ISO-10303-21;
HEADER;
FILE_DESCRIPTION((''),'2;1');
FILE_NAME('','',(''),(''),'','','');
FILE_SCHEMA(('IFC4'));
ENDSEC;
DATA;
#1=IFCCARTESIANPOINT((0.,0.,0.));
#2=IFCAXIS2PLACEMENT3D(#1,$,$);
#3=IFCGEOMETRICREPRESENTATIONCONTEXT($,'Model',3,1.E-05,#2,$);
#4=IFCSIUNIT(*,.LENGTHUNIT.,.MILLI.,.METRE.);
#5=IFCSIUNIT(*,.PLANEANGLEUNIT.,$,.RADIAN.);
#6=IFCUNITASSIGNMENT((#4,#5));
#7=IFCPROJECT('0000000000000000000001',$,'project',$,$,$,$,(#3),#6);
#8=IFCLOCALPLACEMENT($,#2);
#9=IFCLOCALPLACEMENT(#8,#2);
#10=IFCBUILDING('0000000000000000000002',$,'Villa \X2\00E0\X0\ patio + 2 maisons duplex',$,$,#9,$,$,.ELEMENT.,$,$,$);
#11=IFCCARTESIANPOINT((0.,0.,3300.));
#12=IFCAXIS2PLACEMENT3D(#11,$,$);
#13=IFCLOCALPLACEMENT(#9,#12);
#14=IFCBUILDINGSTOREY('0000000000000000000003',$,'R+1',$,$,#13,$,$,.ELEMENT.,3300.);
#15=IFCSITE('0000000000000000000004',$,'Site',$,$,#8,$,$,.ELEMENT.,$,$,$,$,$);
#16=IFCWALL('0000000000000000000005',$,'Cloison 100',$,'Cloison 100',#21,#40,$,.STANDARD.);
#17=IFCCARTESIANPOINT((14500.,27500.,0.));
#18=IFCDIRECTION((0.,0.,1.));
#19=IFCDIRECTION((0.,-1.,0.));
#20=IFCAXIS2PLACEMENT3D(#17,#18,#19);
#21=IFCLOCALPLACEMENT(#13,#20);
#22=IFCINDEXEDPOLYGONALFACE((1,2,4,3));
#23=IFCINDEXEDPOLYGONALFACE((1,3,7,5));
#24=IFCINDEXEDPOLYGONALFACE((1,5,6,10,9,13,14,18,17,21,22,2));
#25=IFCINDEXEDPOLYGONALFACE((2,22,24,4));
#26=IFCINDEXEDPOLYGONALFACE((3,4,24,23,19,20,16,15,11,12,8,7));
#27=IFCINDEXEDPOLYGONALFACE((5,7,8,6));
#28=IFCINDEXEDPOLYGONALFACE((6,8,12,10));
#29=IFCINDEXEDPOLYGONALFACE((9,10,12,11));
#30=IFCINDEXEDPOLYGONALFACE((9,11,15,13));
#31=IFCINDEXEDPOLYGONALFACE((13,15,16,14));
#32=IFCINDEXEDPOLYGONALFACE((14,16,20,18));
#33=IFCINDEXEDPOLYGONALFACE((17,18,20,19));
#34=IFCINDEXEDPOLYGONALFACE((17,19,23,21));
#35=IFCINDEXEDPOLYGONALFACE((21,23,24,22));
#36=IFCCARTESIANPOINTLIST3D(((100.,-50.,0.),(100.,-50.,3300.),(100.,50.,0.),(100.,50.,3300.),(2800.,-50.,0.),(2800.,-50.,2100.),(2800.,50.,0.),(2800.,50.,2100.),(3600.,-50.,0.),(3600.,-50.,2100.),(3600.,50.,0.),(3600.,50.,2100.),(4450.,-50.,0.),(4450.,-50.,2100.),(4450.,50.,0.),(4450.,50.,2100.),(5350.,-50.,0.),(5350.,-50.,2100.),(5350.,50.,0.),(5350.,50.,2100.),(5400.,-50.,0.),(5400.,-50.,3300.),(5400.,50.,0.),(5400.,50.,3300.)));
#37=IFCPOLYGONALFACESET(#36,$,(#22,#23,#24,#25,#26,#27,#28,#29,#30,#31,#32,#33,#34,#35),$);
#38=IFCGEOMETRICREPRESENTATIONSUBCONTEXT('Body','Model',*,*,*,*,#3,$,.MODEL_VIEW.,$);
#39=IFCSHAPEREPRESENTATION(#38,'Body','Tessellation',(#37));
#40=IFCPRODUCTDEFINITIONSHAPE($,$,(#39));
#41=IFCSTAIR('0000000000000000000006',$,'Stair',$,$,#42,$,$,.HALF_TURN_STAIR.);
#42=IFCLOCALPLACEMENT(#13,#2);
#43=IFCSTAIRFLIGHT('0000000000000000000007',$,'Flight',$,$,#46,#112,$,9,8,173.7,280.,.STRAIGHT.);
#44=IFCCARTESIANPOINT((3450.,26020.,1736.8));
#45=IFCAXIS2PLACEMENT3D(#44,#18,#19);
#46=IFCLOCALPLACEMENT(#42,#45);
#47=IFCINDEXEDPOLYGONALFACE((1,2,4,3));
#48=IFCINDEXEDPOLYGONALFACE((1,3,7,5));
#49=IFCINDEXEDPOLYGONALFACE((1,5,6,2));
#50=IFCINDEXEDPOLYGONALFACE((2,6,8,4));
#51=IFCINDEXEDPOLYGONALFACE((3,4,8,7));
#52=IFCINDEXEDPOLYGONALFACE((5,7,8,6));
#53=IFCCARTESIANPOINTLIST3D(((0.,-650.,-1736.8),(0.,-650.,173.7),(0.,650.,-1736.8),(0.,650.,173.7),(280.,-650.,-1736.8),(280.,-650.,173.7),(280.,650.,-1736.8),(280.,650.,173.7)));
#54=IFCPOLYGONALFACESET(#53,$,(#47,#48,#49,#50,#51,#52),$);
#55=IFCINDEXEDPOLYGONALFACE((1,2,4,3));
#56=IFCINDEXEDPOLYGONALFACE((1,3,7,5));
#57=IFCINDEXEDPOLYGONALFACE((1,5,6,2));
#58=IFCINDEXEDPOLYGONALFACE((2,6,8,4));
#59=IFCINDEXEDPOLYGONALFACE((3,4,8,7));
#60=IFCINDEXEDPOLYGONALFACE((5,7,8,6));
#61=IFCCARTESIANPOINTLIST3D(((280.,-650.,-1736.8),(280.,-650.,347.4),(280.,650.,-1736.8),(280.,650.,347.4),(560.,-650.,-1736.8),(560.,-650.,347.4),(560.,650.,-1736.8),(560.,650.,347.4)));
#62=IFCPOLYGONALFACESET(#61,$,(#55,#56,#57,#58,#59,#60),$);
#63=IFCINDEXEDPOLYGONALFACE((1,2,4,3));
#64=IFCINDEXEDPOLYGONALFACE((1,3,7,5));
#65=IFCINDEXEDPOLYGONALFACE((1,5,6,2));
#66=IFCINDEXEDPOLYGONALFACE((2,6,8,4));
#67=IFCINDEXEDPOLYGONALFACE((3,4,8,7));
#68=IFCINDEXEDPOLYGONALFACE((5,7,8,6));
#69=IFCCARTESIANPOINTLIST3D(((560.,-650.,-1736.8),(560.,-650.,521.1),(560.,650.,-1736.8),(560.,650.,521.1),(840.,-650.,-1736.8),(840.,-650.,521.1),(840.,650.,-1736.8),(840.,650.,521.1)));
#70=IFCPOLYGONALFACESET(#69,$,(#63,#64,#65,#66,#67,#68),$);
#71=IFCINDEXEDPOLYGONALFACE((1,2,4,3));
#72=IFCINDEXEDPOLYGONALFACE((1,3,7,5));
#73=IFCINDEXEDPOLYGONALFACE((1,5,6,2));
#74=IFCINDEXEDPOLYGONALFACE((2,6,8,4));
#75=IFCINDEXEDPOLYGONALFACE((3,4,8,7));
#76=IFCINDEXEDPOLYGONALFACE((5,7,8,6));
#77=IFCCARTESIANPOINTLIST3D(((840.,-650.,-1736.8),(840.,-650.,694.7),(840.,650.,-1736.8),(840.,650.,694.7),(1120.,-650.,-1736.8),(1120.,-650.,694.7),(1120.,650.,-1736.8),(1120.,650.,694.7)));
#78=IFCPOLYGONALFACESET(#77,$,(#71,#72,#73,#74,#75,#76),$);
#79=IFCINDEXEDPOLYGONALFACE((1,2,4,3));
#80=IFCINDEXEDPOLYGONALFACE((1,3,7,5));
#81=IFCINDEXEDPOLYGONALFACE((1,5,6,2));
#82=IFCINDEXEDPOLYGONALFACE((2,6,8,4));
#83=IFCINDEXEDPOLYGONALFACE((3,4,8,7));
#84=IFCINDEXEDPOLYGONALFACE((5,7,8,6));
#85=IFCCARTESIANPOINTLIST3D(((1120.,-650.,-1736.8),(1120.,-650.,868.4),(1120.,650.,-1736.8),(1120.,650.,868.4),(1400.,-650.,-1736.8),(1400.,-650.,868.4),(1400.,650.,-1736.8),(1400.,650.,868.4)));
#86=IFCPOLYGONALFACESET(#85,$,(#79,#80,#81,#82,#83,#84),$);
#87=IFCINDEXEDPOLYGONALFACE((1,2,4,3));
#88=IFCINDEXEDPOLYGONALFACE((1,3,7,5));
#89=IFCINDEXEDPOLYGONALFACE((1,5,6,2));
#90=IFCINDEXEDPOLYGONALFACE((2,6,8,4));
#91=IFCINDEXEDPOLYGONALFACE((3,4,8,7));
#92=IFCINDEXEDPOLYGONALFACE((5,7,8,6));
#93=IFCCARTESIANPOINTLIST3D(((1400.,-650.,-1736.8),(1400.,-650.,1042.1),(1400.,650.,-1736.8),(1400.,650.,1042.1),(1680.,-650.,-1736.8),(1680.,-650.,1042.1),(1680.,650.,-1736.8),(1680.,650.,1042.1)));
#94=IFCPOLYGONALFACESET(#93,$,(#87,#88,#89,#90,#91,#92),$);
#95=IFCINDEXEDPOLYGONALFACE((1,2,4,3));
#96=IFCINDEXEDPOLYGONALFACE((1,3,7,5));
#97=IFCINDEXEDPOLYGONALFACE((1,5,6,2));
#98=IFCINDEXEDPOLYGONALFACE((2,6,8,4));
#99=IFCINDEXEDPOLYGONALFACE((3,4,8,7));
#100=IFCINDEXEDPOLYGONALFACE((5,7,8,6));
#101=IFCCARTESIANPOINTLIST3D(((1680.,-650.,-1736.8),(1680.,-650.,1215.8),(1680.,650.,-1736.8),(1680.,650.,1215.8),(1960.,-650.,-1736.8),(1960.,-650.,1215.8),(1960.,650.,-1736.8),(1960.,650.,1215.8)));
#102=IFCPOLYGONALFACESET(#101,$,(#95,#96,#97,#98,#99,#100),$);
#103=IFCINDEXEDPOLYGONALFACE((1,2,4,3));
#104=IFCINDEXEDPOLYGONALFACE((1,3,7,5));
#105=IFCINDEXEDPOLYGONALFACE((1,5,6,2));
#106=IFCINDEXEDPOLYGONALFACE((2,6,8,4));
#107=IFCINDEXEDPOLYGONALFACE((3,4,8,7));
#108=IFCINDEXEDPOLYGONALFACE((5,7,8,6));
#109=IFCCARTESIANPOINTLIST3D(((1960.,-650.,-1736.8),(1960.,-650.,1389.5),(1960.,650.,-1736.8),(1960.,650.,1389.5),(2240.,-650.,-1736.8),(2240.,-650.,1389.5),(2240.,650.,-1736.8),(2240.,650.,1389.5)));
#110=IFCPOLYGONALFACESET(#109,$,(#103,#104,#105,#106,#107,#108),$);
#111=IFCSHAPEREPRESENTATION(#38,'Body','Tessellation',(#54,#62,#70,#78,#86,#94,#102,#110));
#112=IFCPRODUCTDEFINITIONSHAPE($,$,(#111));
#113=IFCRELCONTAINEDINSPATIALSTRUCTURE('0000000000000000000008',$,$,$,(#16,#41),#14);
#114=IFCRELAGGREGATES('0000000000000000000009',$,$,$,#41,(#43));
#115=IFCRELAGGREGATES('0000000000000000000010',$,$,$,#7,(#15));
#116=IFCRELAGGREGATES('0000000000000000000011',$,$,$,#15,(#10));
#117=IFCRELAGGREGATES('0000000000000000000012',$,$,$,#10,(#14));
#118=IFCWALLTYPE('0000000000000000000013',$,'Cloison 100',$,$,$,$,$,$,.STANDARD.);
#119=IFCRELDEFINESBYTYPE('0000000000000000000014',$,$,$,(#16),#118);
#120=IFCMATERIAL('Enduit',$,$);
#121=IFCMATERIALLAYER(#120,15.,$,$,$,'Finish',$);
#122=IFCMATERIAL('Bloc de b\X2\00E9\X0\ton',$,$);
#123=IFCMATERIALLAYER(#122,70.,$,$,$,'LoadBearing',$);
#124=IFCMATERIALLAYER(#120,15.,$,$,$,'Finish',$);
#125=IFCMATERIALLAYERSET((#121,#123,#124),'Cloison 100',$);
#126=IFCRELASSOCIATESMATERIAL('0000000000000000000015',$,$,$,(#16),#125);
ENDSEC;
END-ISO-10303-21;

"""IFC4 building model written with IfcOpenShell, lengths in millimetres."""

from ifc_helpers import new_model, si_unit, frame, frame_2d, origin, place, context, subcontext, project, spatial, polyline, rectangle, outline, extrude, material, layer, layer_set, layer_usage, type_object, element, aggregate, save


model = new_model("IFC4")

# Units and contexts
model_context = context("Model", 3, precision=1e-05, world=origin())
body_context = subcontext(model_context, "Body", "Model", "MODEL_VIEW")
ifc_project = project(units=[si_unit("LENGTHUNIT", "METRE", prefix="MILLI"), si_unit("PLANEANGLEUNIT", "RADIAN")], contexts=[model_context])

# Site, building, storey
site_placement = place(None, origin())
site = spatial("IfcSite", under=ifc_project, at=site_placement, Name="Site", CompositionType="ELEMENT")
building_placement = place(site_placement, origin())
building = spatial("IfcBuilding", under=site, at=building_placement, Name="Villa à patio + 2 maisons duplex", CompositionType="ELEMENT")
storey_placement = place(building_placement, frame((0.0, 0.0, 3300.0)))
storey = spatial("IfcBuildingStorey", under=building, at=storey_placement, Name="R+1", CompositionType="ELEMENT", Elevation=3300.0)

# Shared definitions
ifc_material_1 = material(Name="Enduit")
ifc_layer_1 = layer(ifc_material_1, 15.0, Category="Finish")
ifc_material_2 = material(Name="Bloc de béton")
ifc_layer_2 = layer(ifc_material_2, 70.0, Category="LoadBearing")
ifc_layer_3 = layer(ifc_material_1, 15.0, Category="Finish")
ifc_layer_set_1 = layer_set([ifc_layer_1, ifc_layer_2, ifc_layer_3], Name="Cloison 100")
ifc_layer_usage_1 = layer_usage(ifc_layer_set_1, "AXIS2", "NEGATIVE", 50.0)
wall_type_1 = type_object("IfcWallType", Name="Cloison 100", PredefinedType="STANDARD")

# Wall, openings
wall_1_placement = place(storey_placement, frame((14500.0, 27500.0, 0.0), z_axis=(0.0, 0.0, 1.0), x_axis=(0.0, -1.0, 0.0)))
wall_1 = element("IfcWall", 1, at=wall_1_placement, inside=storey, type_object=wall_type_1, material=ifc_layer_usage_1, Name="Cloison 100", ObjectType="Cloison 100", PredefinedType="STANDARD", context=body_context, shape_type="SweptSolid", body=[
    extrude(outline(polyline([(100.0, -50.0), (100.0, 50.0), (5400.0, 50.0), (5400.0, -50.0), (100.0, -50.0)])), origin(), (0.0, 0.0, 1.0), 3300.0),
])
opening_1_placement = place(wall_1_placement, frame((4450.0, 0.0, 0.0), z_axis=(0.0, 0.0, 1.0), x_axis=(1.0, 0.0, 0.0)))
element("IfcOpeningElement", 2, at=opening_1_placement, cuts=wall_1, PredefinedType="OPENING", context=body_context, shape_type="SweptSolid", body=[
    extrude(rectangle(XDim=900.0, YDim=120.0, at=frame_2d((450.0, 0.0))), origin(), (0.0, 0.0, 1.0), 2100.0),
])
opening_2_placement = place(wall_1_placement, frame((2800.0, 0.0, 0.0), z_axis=(0.0, 0.0, 1.0), x_axis=(1.0, 0.0, 0.0)))
element("IfcOpeningElement", 3, at=opening_2_placement, cuts=wall_1, PredefinedType="OPENING", context=body_context, shape_type="SweptSolid", body=[
    extrude(rectangle(XDim=800.0, YDim=120.0, at=frame_2d((400.0, 0.0))), origin(), (0.0, 0.0, 1.0), 2100.0),
])

# Stair, stair flight
stair_placement = place(storey_placement, origin())
stair = element("IfcStair", 4, at=stair_placement, inside=storey, Name="Stair", PredefinedType="HALF_TURN_STAIR")
stair_flight_placement = place(stair_placement, frame((3450.0, 26020.0, 1736.8), z_axis=(0.0, 0.0, 1.0), x_axis=(0.0, -1.0, 0.0)))
stair_flight = element("IfcStairFlight", 5, at=stair_flight_placement, Name="Flight", NumberOfRisers=9, NumberOfTreads=8, PredefinedType="STRAIGHT", RiserHeight=173.7, TreadLength=280.0, context=body_context, shape_type="SweptSolid", body=[
    extrude(rectangle(XDim=280.0, YDim=1300.0, at=frame_2d((140.0, 0.0))), frame((0.0, 0.0, -1736.8)), (0.0, 0.0, 1.0), 1910.5),
    extrude(rectangle(XDim=280.0, YDim=1300.0, at=frame_2d((420.0, 0.0))), frame((0.0, 0.0, -1736.8)), (0.0, 0.0, 1.0), 2084.2),
    extrude(rectangle(XDim=280.0, YDim=1300.0, at=frame_2d((700.0, 0.0))), frame((0.0, 0.0, -1736.8)), (0.0, 0.0, 1.0), 2257.9),
    extrude(rectangle(XDim=280.0, YDim=1300.0, at=frame_2d((980.0, 0.0))), frame((0.0, 0.0, -1736.8)), (0.0, 0.0, 1.0), 2431.6),
    extrude(rectangle(XDim=280.0, YDim=1300.0, at=frame_2d((1260.0, 0.0))), frame((0.0, 0.0, -1736.8)), (0.0, 0.0, 1.0), 2605.3),
    extrude(rectangle(XDim=280.0, YDim=1300.0, at=frame_2d((1540.0, 0.0))), frame((0.0, 0.0, -1736.8)), (0.0, 0.0, 1.0), 2778.9),
    extrude(rectangle(XDim=280.0, YDim=1300.0, at=frame_2d((1820.0, 0.0))), frame((0.0, 0.0, -1736.8)), (0.0, 0.0, 1.0), 2952.6),
    extrude(rectangle(XDim=280.0, YDim=1300.0, at=frame_2d((2100.0, 0.0))), frame((0.0, 0.0, -1736.8)), (0.0, 0.0, 1.0), 3126.3),
])
aggregate(stair, [stair_flight])

save(model, "model.ifc")
